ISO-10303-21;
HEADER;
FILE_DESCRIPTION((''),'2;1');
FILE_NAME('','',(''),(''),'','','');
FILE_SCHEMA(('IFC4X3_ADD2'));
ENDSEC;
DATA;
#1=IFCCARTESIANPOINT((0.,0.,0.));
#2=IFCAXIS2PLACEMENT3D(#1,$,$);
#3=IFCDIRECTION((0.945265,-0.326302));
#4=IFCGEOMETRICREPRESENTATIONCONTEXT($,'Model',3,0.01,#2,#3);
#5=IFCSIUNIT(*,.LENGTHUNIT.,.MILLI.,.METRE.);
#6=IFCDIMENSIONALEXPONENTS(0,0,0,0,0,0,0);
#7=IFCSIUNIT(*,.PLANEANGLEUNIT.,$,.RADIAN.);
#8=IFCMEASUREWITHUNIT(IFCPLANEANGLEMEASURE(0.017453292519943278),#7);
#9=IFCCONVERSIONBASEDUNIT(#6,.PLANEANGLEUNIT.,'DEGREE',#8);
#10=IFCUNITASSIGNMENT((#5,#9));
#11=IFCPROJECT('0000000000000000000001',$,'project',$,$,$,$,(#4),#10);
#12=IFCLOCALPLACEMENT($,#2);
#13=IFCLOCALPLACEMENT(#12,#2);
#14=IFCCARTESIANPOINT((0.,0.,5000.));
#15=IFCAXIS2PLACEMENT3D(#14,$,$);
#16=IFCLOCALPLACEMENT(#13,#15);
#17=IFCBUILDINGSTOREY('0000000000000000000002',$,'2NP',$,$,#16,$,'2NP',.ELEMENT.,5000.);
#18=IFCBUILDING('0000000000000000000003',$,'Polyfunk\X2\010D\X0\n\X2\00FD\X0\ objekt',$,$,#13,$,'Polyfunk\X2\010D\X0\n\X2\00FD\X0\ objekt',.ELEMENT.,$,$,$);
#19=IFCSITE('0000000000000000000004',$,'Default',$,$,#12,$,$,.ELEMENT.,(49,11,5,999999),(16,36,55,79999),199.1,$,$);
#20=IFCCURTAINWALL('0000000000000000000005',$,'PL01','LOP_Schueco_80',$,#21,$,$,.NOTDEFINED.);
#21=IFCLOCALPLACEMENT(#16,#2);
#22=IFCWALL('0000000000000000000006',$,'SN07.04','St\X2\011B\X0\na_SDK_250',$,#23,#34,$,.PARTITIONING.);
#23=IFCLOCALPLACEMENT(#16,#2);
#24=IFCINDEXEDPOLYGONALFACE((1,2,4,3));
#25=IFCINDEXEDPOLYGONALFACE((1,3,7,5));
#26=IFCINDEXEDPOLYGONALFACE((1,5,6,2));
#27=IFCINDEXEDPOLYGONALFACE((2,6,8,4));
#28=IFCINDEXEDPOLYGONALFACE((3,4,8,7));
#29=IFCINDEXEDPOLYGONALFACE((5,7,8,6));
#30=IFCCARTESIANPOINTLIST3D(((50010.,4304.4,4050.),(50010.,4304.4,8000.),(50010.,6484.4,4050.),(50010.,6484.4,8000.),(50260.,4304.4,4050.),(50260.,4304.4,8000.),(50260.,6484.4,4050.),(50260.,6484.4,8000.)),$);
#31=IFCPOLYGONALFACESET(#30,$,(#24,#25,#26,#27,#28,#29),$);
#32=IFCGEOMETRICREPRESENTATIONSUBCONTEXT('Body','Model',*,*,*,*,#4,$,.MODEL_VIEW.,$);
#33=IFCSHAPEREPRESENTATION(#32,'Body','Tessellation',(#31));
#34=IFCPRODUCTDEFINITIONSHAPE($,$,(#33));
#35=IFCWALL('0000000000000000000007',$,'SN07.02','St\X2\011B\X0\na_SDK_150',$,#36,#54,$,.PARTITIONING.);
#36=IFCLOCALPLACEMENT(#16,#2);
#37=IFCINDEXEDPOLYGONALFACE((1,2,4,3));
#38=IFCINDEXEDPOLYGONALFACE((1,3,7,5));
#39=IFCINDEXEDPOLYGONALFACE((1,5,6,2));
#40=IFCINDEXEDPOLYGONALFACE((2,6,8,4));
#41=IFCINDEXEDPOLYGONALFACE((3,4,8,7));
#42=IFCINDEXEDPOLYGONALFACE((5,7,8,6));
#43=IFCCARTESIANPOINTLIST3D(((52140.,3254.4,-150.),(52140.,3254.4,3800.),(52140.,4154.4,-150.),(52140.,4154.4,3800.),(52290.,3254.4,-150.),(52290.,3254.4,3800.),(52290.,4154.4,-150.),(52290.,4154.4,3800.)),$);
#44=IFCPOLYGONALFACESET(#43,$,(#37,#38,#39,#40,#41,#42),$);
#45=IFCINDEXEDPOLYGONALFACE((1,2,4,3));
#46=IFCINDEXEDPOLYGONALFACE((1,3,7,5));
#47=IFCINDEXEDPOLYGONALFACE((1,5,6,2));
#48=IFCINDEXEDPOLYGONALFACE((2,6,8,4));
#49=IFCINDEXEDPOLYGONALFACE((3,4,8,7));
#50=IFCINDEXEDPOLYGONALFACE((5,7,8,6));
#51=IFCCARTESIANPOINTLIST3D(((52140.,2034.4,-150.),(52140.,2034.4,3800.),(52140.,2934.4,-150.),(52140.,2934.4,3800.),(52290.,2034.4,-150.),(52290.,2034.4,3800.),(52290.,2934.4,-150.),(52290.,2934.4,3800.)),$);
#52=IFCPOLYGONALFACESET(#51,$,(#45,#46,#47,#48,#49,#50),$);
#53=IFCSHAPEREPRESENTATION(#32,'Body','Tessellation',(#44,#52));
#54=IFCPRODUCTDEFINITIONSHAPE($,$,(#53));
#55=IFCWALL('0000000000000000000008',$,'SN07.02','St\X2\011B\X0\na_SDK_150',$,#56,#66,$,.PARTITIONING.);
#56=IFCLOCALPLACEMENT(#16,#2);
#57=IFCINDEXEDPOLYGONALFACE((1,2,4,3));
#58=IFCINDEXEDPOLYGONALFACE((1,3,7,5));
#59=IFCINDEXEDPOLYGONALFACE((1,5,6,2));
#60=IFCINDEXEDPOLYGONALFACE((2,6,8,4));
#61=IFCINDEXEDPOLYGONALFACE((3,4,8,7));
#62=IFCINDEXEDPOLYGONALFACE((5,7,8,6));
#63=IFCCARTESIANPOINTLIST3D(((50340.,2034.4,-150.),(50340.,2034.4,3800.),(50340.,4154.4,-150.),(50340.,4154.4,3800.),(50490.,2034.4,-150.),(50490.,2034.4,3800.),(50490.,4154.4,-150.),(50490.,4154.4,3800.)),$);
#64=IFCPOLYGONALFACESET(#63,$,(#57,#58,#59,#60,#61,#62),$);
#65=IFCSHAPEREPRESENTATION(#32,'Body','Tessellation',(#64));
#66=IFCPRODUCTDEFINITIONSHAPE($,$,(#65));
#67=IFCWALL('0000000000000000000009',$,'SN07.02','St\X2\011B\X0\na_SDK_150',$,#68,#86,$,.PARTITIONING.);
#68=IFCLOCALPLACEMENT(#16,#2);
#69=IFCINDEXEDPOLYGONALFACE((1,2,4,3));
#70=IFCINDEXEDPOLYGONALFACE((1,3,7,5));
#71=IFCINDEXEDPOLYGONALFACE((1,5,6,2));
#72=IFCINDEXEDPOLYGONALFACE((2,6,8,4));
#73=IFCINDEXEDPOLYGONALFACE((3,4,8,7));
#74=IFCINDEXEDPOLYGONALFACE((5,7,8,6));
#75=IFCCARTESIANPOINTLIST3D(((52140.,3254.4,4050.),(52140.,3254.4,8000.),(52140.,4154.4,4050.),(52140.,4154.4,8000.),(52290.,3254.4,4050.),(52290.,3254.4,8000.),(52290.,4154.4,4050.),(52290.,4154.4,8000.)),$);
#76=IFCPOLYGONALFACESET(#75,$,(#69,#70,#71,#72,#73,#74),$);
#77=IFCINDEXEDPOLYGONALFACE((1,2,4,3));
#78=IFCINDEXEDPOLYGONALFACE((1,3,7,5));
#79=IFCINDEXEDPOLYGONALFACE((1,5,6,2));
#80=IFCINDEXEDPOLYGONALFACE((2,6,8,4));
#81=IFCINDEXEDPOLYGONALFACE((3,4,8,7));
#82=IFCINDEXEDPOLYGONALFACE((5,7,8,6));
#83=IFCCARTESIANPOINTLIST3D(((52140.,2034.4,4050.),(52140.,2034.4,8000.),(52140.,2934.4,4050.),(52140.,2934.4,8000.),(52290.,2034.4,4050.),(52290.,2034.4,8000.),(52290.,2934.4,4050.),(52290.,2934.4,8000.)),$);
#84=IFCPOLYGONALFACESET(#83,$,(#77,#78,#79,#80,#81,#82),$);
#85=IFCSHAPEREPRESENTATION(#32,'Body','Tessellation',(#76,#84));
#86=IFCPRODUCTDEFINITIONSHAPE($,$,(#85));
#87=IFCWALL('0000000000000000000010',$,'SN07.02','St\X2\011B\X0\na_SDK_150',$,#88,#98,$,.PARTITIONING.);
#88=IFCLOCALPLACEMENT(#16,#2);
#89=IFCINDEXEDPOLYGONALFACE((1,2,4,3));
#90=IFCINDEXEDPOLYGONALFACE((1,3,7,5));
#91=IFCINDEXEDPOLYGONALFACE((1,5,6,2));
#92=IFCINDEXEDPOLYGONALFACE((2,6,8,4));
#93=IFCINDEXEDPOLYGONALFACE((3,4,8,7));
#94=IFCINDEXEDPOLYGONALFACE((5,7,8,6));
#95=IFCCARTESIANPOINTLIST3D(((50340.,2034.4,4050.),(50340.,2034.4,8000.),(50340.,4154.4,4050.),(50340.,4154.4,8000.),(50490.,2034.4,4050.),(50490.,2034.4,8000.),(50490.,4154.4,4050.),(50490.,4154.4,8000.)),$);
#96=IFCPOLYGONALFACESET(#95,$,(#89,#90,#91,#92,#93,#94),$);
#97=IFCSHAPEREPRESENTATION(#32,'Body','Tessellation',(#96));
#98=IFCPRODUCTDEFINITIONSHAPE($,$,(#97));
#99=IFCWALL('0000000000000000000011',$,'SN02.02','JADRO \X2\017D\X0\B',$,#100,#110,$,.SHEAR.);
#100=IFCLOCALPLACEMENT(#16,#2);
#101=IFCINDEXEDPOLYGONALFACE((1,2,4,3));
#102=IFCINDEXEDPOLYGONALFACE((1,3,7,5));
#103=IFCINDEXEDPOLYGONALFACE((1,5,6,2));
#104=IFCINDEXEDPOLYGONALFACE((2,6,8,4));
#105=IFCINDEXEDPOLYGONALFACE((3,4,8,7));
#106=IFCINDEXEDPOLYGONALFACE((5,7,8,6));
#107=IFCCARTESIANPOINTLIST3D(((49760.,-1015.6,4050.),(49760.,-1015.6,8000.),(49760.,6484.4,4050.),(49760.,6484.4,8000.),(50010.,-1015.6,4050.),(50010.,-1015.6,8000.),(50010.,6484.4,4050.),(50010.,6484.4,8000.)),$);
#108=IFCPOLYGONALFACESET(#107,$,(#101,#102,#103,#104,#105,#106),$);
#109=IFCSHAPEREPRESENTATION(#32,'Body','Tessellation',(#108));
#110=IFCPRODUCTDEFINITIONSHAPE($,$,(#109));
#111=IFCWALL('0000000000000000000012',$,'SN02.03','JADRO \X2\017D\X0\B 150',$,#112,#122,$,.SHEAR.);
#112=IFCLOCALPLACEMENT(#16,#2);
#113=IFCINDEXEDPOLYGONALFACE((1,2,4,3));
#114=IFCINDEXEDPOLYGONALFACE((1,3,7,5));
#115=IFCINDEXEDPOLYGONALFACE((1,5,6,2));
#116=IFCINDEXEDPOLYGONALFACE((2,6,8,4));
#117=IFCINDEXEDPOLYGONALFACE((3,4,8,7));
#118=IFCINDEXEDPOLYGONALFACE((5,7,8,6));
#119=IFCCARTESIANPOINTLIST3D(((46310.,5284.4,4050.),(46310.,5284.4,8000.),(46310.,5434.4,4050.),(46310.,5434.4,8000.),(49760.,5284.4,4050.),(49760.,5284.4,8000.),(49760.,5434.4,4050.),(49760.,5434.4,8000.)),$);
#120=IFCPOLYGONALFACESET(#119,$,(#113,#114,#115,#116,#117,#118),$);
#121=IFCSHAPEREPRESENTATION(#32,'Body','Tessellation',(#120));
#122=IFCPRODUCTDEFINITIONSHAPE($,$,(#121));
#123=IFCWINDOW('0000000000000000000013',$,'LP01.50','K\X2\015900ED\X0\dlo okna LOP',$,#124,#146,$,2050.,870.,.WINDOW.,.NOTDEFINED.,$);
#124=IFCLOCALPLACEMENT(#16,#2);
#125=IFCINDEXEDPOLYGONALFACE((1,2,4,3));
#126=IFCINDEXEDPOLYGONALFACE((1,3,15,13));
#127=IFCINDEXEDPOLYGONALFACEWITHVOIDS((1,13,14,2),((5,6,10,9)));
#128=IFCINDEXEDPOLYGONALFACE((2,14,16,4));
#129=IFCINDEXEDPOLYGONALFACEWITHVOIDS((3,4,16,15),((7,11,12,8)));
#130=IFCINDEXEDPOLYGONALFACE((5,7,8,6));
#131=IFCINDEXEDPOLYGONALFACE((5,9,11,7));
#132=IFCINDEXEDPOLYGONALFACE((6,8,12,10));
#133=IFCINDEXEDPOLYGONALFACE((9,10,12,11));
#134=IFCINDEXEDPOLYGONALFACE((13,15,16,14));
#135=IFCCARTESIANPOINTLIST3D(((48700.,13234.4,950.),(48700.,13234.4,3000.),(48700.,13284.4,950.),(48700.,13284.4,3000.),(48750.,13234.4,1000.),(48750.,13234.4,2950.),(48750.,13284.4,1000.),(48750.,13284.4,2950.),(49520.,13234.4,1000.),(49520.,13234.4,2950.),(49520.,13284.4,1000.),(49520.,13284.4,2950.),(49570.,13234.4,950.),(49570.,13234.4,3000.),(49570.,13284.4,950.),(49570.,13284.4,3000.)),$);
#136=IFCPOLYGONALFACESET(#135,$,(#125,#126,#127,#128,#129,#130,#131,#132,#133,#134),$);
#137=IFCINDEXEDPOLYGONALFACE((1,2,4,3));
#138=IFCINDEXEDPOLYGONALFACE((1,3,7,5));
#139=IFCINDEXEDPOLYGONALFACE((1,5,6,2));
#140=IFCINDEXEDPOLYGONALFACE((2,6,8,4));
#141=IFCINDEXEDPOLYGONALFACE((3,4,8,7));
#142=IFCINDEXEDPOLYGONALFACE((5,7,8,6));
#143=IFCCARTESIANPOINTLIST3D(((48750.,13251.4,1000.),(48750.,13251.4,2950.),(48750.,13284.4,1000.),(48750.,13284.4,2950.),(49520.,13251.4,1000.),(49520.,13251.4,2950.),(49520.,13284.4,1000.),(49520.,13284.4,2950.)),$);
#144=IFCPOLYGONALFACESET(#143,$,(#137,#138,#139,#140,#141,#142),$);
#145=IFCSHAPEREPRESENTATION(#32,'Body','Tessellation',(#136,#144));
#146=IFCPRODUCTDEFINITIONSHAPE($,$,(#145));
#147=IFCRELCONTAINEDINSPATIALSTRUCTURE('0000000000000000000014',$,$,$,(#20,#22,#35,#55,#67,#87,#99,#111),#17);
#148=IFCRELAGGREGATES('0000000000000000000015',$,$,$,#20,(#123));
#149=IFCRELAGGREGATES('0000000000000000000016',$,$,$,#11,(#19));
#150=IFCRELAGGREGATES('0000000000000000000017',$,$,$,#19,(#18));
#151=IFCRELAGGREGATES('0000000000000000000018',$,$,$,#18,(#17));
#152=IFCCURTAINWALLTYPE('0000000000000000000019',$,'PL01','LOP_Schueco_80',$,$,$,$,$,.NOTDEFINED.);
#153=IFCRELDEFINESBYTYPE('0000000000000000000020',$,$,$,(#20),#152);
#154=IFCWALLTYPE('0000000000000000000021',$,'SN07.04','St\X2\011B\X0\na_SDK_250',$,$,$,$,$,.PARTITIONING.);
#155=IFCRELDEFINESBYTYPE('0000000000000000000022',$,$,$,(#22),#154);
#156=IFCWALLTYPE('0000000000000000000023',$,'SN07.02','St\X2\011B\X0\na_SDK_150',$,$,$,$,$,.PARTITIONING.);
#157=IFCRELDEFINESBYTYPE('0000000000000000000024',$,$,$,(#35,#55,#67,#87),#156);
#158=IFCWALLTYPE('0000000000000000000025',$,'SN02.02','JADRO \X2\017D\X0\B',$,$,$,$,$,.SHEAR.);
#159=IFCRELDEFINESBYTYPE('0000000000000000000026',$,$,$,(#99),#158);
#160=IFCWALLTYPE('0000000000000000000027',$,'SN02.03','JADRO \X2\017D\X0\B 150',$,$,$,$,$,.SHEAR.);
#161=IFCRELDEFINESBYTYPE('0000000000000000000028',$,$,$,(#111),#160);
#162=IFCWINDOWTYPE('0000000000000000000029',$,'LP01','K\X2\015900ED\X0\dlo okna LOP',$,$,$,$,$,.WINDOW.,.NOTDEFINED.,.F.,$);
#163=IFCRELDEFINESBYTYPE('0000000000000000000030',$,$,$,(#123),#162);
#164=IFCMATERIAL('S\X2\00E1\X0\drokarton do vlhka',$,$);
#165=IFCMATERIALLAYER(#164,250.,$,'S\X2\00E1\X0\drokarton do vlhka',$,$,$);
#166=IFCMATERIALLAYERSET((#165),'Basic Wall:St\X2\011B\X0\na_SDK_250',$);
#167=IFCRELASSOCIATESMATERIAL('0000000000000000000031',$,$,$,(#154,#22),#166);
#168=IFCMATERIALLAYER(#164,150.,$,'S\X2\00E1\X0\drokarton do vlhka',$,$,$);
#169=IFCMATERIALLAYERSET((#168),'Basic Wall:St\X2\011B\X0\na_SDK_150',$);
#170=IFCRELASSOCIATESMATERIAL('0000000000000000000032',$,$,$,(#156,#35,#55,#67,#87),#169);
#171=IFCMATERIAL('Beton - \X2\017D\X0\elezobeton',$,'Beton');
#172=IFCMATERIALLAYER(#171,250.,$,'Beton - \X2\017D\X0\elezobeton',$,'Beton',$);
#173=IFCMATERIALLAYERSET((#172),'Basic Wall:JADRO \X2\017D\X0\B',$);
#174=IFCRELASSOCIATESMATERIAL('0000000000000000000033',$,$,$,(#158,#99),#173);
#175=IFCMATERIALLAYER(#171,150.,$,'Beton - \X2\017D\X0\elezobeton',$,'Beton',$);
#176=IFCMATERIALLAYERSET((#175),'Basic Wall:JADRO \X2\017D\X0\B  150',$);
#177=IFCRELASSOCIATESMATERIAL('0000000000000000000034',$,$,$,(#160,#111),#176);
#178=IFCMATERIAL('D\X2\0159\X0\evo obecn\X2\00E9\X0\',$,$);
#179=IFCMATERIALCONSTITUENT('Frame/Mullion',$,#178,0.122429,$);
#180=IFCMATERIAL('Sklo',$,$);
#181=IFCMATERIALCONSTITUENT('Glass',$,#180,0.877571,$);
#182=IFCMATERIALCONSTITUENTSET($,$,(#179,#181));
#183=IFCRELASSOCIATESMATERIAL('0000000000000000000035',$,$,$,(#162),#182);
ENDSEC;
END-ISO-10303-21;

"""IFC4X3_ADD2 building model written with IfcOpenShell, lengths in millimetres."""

from ifc_helpers import new_model, entity, si_unit, converted_unit, direction, frame, frame_2d, origin, origin_2d_with_axis, place, context, subcontext, project, spatial, polyline, rectangle, outline, extrude, clip, bounded_halfspace, source, transform, mapped, material, layer, layer_set, constituent, constituent_set, type_object, type_shapes, element, aggregate, save


model = new_model("IFC4X3_ADD2")

# Units and contexts
model_context = context("Model", 3, precision=0.01, world=origin(), true_north=direction((0.945265, -0.326302)))
body_context = subcontext(model_context, "Body", "Model", "MODEL_VIEW")
ifc_project = project(units=[si_unit("LENGTHUNIT", "METRE", prefix="MILLI"), converted_unit("PLANEANGLEUNIT", "DEGREE", entity("IfcPlaneAngleMeasure", 0.017453292519943278), si_unit("PLANEANGLEUNIT", "RADIAN"), dimensions=[0, 0, 0, 0, 0, 0, 0])], contexts=[model_context])

# Site, building, storey
site_placement = place(None, origin())
site = spatial("IfcSite", under=ifc_project, at=site_placement, Name="Default", CompositionType="ELEMENT", RefLatitude=(49, 11, 5, 999999), RefLongitude=(16, 36, 55, 79999), RefElevation=199.1)
building_placement = place(site_placement, origin())
building = spatial("IfcBuilding", under=site, at=building_placement, Name="Polyfunkčný objekt", LongName="Polyfunkčný objekt", CompositionType="ELEMENT")
storey_placement = place(building_placement, frame((0.0, 0.0, 5000.0)))
storey = spatial("IfcBuildingStorey", under=building, at=storey_placement, Name="2NP", LongName="2NP", CompositionType="ELEMENT", Elevation=5000.0)

# Curtain wall
curtain_wall_type = type_object("IfcCurtainWallType", Name="PL01", Description="LOP_Schueco_80", PredefinedType="NOTDEFINED")
curtain_wall_placement = place(storey_placement, frame((0.0, 0.0, -5000.0)))
curtain_wall = element("IfcCurtainWall", 1, at=curtain_wall_placement, inside=storey, type_object=curtain_wall_type, Name="PL01", Description="LOP_Schueco_80", PredefinedType="NOTDEFINED")
ifc_material_1 = material(Name="Sklo")

# Walls
ifc_material_2 = material(Name="Sádrokarton do vlhka")
ifc_layer_1 = layer(ifc_material_2, 250.0, Name="Sádrokarton do vlhka")
ifc_layer_set_1 = layer_set([ifc_layer_1], Name="Basic Wall:Stěna_SDK_250")
wall_type_1 = type_object("IfcWallType", Name="SN07.04", Description="Stěna_SDK_250", PredefinedType="PARTITIONING", material=ifc_layer_set_1)
wall_1_placement = place(storey_placement, frame((50135.0, 6484.4, 4050.0), z_axis=(0.0, 0.0, 1.0), x_axis=(0.0, -1.0, 0.0)))
element("IfcWall", 2, at=wall_1_placement, inside=storey, type_object=wall_type_1, material=ifc_layer_set_1, Name="SN07.04", Description="Stěna_SDK_250", PredefinedType="PARTITIONING", context=body_context, shape_type="Clipping", body=[
    clip(clip(extrude(rectangle(XDim=2180.0, YDim=250.0, at=frame_2d((1090.0, 0.0), x_axis=(-1.0, 0.0))), origin(), (0.0, 0.0, 1.0), 3950.0), bounded_halfspace(frame((2180.0, -125.0, 0.0), z_axis=(0.0, 0.0, 1.0), x_axis=(0.0, -1.0, 0.0)), True, frame((2180.0, -125.0, 0.0)), polyline([(0.0, 0.0), (0.0, 250.0), (-1930.0, 250.0), (-2180.0, 250.0), (-2180.0, 0.0), (0.0, 0.0)]))), bounded_halfspace(frame((0.0, -125.0, 3950.0), z_axis=(0.0, 0.0, -1.0), x_axis=(0.0, 1.0, 0.0)), True, frame((0.0, -125.0, 3950.0)), polyline([(0.0, 0.0), (2180.0, 0.0), (2180.0, 250.0), (250.0, 250.0), (0.0, 250.0), (0.0, 0.0)]))),
])
ifc_layer_2 = layer(ifc_material_2, 150.0, Name="Sádrokarton do vlhka")
ifc_layer_set_2 = layer_set([ifc_layer_2], Name="Basic Wall:Stěna_SDK_150")
wall_type_2 = type_object("IfcWallType", Name="SN07.02", Description="Stěna_SDK_150", PredefinedType="PARTITIONING", material=ifc_layer_set_2)
wall_2_placement = place(storey_placement, frame((52215.0, 4154.4, -150.0), z_axis=(0.0, 0.0, 1.0), x_axis=(0.0, -1.0, 0.0)))
element("IfcWall", 3, at=wall_2_placement, inside=storey, type_object=wall_type_2, material=ifc_layer_set_2, Name="SN07.02", Description="Stěna_SDK_150", PredefinedType="PARTITIONING", context=body_context, shape_type="SweptSolid", body=[
    extrude(rectangle(XDim=900.0, YDim=150.0, at=frame_2d((0.0, 0.0), x_axis=(1.0, 0.0))), frame((450.0, 0.0, 0.0)), (0.0, 0.0, 1.0), 3950.0),
    extrude(rectangle(XDim=900.0, YDim=150.0, at=frame_2d((0.0, 0.0), x_axis=(1.0, 0.0))), frame((1670.0, 0.0, 0.0), z_axis=(0.0, 0.0, 1.0), x_axis=(-1.0, 0.0, 0.0)), (0.0, 0.0, 1.0), 3950.0),
])
wall_3_placement = place(storey_placement, frame((50415.0, 4154.4, -150.0), z_axis=(0.0, 0.0, 1.0), x_axis=(0.0, -1.0, 0.0)))
element("IfcWall", 4, at=wall_3_placement, inside=storey, type_object=wall_type_2, material=ifc_layer_set_2, Name="SN07.02", Description="Stěna_SDK_150", PredefinedType="PARTITIONING", context=body_context, shape_type="Clipping", body=[
    clip(clip(extrude(rectangle(XDim=2120.0, YDim=150.0, at=frame_2d((1060.0, 0.0), x_axis=(-1.0, 0.0))), origin(), (0.0, 0.0, 1.0), 3950.0), bounded_halfspace(frame((2120.0, -75.0, 0.0), z_axis=(0.0, 0.0, 1.0), x_axis=(0.0, -1.0, 0.0)), True, frame((2120.0, -75.0, 0.0)), polyline([(0.0, 0.0), (0.0, 150.0), (-900.0, 150.0), (-1220.0, 150.0), (-2120.0, 150.0), (-2120.0, 0.0), (0.0, 0.0)]))), bounded_halfspace(frame((0.0, -75.0, 3950.0), z_axis=(0.0, 0.0, -1.0), x_axis=(0.0, 1.0, 0.0)), True, frame((0.0, -75.0, 3950.0)), polyline([(0.0, 0.0), (2120.0, 0.0), (2120.0, 150.0), (1220.0, 150.0), (900.0, 150.0), (0.0, 150.0), (0.0, 0.0)]))),
])
wall_4_placement = place(storey_placement, frame((52215.0, 4154.4, 4050.0), z_axis=(0.0, 0.0, 1.0), x_axis=(0.0, -1.0, 0.0)))
element("IfcWall", 5, at=wall_4_placement, inside=storey, type_object=wall_type_2, material=ifc_layer_set_2, Name="SN07.02", Description="Stěna_SDK_150", PredefinedType="PARTITIONING", context=body_context, shape_type="SweptSolid", body=[
    extrude(rectangle(XDim=900.0, YDim=150.0, at=frame_2d((0.0, 0.0), x_axis=(1.0, 0.0))), frame((450.0, 0.0, 0.0)), (0.0, 0.0, 1.0), 3950.0),
    extrude(rectangle(XDim=900.0, YDim=150.0, at=frame_2d((0.0, 0.0), x_axis=(1.0, 0.0))), frame((1670.0, 0.0, 0.0), z_axis=(0.0, 0.0, 1.0), x_axis=(-1.0, 0.0, 0.0)), (0.0, 0.0, 1.0), 3950.0),
])
wall_5_placement = place(storey_placement, frame((50415.0, 4154.4, 4050.0), z_axis=(0.0, 0.0, 1.0), x_axis=(0.0, -1.0, 0.0)))
element("IfcWall", 6, at=wall_5_placement, inside=storey, type_object=wall_type_2, material=ifc_layer_set_2, Name="SN07.02", Description="Stěna_SDK_150", PredefinedType="PARTITIONING", context=body_context, shape_type="Clipping", body=[
    clip(clip(extrude(rectangle(XDim=2120.0, YDim=150.0, at=frame_2d((1060.0, 0.0), x_axis=(-1.0, 0.0))), origin(), (0.0, 0.0, 1.0), 3950.0), bounded_halfspace(frame((2120.0, -75.0, 0.0), z_axis=(0.0, 0.0, 1.0), x_axis=(0.0, -1.0, 0.0)), True, frame((2120.0, -75.0, 0.0)), polyline([(0.0, 0.0), (0.0, 150.0), (-900.0, 150.0), (-1220.0, 150.0), (-2120.0, 150.0), (-2120.0, 0.0), (0.0, 0.0)]))), bounded_halfspace(frame((0.0, -75.0, 3950.0), z_axis=(0.0, 0.0, -1.0), x_axis=(0.0, 1.0, 0.0)), True, frame((0.0, -75.0, 3950.0)), polyline([(0.0, 0.0), (2120.0, 0.0), (2120.0, 150.0), (1220.0, 150.0), (900.0, 150.0), (0.0, 150.0), (0.0, 0.0)]))),
])
ifc_material_3 = material(Name="Beton - Železobeton", Category="Beton")
ifc_layer_3 = layer(ifc_material_3, 250.0, Name="Beton - Železobeton", Category="Beton")
ifc_layer_set_3 = layer_set([ifc_layer_3], Name="Basic Wall:JADRO ŽB")
wall_type_3 = type_object("IfcWallType", Name="SN02.02", Description="JADRO ŽB", PredefinedType="SHEAR", material=ifc_layer_set_3)
wall_6_placement = place(storey_placement, frame((49885.0, 6484.4, 4050.0), z_axis=(0.0, 0.0, 1.0), x_axis=(0.0, -1.0, 0.0)))
element("IfcWall", 7, at=wall_6_placement, inside=storey, type_object=wall_type_3, material=ifc_layer_set_3, Name="SN02.02", Description="JADRO ŽB", PredefinedType="SHEAR", context=body_context, shape_type="Clipping", body=[
    clip(clip(extrude(rectangle(XDim=7500.0, YDim=250.0, at=frame_2d((3750.0, 0.0), x_axis=(-1.0, 0.0))), origin(), (0.0, 0.0, 1.0), 3950.0), bounded_halfspace(frame((7500.0, -125.0, 0.0), z_axis=(0.0, 0.0, 1.0), x_axis=(0.0, -1.0, 0.0)), True, frame((7500.0, -125.0, 0.0)), polyline([(0.0, 0.0), (0.0, 250.0), (-7500.0, 250.0), (-7500.0, 0.0), (-7250.0, 0.0), (-6450.0, 0.0), (-6300.0, 0.0), (0.0, 0.0)]))), bounded_halfspace(frame((0.0, -125.0, 3950.0), z_axis=(0.0, 0.0, -1.0), x_axis=(0.0, 1.0, 0.0)), True, frame((0.0, -125.0, 3950.0)), polyline([(0.0, 0.0), (250.0, 0.0), (1050.0, 0.0), (1200.0, 0.0), (7500.0, 0.0), (7500.0, 250.0), (0.0, 250.0), (0.0, 0.0)]))),
])
ifc_layer_4 = layer(ifc_material_3, 150.0, Name="Beton - Železobeton", Category="Beton")
ifc_layer_set_4 = layer_set([ifc_layer_4], Name="Basic Wall:JADRO ŽB  150")
wall_type_4 = type_object("IfcWallType", Name="SN02.03", Description="JADRO ŽB 150", PredefinedType="SHEAR", material=ifc_layer_set_4)
wall_7_placement = place(storey_placement, frame((46310.0, 5359.4, 4050.0)))
element("IfcWall", 8, at=wall_7_placement, inside=storey, type_object=wall_type_4, material=ifc_layer_set_4, Name="SN02.03", Description="JADRO ŽB 150", PredefinedType="SHEAR", context=body_context, shape_type="SweptSolid", body=[
    extrude(rectangle(XDim=3450.0, YDim=150.0, at=frame_2d((1725.0, 0.0), x_axis=(-1.0, 0.0))), origin(), (0.0, 0.0, 1.0), 3950.0),
])

# Window
ifc_material_4 = material(Name="Dřevo obecné")
ifc_constituent_1 = constituent(ifc_material_4, Name="Frame/Mullion", fraction=0.122429)
ifc_constituent_2 = constituent(ifc_material_1, Name="Glass", fraction=0.877571)
ifc_constituent_set = constituent_set(constituents=[ifc_constituent_1, ifc_constituent_2])
window_type = type_object("IfcWindowType", Name="LP01", Description="Křídlo okna LOP", ParameterTakesPrecedence=False, PartitioningType="NOTDEFINED", PredefinedType="WINDOW", material=ifc_constituent_set)
shared_shape_1 = source(origin(), body_context, "Body", "SweptSolid", [
    extrude(outline(polyline([(-1025.0, -435.0), (1025.0, -435.0), (1025.0, 435.0), (-1025.0, 435.0), (-1025.0, -435.0)]), holes=[polyline([(-975.0, -385.0), (-975.0, 385.0), (975.0, 385.0), (975.0, -385.0), (-975.0, -385.0)])]), frame((0.0, 0.0, 1025.0), z_axis=(0.0, 1.0, 0.0), x_axis=(0.0, 0.0, -1.0)), (0.0, 0.0, 1.0), 50.0),
    extrude(rectangle(XDim=33.0, YDim=770.0, at=origin_2d_with_axis()), frame((0.0, 33.5, 50.0), z_axis=(0.0, 0.0, 1.0), x_axis=(0.0, -1.0, 0.0)), (0.0, 0.0, 1.0), 1950.0),
])
type_shapes(window_type, [shared_shape_1])
window_placement = place(curtain_wall_placement, frame((49135.0, 13234.4, 5950.0)))
window = element("IfcWindow", 9, at=window_placement, type_object=window_type, Name="LP01.50", Description="Křídlo okna LOP", OverallHeight=2050.0, OverallWidth=870.0, PartitioningType="NOTDEFINED", PredefinedType="WINDOW", context=body_context, shape_type="MappedRepresentation", body=[
    mapped(shared_shape_1, transform((0.0, 0.0, 0.0), scale=1.0)),
])
aggregate(curtain_wall, [window])

save(model, "model.ifc")
